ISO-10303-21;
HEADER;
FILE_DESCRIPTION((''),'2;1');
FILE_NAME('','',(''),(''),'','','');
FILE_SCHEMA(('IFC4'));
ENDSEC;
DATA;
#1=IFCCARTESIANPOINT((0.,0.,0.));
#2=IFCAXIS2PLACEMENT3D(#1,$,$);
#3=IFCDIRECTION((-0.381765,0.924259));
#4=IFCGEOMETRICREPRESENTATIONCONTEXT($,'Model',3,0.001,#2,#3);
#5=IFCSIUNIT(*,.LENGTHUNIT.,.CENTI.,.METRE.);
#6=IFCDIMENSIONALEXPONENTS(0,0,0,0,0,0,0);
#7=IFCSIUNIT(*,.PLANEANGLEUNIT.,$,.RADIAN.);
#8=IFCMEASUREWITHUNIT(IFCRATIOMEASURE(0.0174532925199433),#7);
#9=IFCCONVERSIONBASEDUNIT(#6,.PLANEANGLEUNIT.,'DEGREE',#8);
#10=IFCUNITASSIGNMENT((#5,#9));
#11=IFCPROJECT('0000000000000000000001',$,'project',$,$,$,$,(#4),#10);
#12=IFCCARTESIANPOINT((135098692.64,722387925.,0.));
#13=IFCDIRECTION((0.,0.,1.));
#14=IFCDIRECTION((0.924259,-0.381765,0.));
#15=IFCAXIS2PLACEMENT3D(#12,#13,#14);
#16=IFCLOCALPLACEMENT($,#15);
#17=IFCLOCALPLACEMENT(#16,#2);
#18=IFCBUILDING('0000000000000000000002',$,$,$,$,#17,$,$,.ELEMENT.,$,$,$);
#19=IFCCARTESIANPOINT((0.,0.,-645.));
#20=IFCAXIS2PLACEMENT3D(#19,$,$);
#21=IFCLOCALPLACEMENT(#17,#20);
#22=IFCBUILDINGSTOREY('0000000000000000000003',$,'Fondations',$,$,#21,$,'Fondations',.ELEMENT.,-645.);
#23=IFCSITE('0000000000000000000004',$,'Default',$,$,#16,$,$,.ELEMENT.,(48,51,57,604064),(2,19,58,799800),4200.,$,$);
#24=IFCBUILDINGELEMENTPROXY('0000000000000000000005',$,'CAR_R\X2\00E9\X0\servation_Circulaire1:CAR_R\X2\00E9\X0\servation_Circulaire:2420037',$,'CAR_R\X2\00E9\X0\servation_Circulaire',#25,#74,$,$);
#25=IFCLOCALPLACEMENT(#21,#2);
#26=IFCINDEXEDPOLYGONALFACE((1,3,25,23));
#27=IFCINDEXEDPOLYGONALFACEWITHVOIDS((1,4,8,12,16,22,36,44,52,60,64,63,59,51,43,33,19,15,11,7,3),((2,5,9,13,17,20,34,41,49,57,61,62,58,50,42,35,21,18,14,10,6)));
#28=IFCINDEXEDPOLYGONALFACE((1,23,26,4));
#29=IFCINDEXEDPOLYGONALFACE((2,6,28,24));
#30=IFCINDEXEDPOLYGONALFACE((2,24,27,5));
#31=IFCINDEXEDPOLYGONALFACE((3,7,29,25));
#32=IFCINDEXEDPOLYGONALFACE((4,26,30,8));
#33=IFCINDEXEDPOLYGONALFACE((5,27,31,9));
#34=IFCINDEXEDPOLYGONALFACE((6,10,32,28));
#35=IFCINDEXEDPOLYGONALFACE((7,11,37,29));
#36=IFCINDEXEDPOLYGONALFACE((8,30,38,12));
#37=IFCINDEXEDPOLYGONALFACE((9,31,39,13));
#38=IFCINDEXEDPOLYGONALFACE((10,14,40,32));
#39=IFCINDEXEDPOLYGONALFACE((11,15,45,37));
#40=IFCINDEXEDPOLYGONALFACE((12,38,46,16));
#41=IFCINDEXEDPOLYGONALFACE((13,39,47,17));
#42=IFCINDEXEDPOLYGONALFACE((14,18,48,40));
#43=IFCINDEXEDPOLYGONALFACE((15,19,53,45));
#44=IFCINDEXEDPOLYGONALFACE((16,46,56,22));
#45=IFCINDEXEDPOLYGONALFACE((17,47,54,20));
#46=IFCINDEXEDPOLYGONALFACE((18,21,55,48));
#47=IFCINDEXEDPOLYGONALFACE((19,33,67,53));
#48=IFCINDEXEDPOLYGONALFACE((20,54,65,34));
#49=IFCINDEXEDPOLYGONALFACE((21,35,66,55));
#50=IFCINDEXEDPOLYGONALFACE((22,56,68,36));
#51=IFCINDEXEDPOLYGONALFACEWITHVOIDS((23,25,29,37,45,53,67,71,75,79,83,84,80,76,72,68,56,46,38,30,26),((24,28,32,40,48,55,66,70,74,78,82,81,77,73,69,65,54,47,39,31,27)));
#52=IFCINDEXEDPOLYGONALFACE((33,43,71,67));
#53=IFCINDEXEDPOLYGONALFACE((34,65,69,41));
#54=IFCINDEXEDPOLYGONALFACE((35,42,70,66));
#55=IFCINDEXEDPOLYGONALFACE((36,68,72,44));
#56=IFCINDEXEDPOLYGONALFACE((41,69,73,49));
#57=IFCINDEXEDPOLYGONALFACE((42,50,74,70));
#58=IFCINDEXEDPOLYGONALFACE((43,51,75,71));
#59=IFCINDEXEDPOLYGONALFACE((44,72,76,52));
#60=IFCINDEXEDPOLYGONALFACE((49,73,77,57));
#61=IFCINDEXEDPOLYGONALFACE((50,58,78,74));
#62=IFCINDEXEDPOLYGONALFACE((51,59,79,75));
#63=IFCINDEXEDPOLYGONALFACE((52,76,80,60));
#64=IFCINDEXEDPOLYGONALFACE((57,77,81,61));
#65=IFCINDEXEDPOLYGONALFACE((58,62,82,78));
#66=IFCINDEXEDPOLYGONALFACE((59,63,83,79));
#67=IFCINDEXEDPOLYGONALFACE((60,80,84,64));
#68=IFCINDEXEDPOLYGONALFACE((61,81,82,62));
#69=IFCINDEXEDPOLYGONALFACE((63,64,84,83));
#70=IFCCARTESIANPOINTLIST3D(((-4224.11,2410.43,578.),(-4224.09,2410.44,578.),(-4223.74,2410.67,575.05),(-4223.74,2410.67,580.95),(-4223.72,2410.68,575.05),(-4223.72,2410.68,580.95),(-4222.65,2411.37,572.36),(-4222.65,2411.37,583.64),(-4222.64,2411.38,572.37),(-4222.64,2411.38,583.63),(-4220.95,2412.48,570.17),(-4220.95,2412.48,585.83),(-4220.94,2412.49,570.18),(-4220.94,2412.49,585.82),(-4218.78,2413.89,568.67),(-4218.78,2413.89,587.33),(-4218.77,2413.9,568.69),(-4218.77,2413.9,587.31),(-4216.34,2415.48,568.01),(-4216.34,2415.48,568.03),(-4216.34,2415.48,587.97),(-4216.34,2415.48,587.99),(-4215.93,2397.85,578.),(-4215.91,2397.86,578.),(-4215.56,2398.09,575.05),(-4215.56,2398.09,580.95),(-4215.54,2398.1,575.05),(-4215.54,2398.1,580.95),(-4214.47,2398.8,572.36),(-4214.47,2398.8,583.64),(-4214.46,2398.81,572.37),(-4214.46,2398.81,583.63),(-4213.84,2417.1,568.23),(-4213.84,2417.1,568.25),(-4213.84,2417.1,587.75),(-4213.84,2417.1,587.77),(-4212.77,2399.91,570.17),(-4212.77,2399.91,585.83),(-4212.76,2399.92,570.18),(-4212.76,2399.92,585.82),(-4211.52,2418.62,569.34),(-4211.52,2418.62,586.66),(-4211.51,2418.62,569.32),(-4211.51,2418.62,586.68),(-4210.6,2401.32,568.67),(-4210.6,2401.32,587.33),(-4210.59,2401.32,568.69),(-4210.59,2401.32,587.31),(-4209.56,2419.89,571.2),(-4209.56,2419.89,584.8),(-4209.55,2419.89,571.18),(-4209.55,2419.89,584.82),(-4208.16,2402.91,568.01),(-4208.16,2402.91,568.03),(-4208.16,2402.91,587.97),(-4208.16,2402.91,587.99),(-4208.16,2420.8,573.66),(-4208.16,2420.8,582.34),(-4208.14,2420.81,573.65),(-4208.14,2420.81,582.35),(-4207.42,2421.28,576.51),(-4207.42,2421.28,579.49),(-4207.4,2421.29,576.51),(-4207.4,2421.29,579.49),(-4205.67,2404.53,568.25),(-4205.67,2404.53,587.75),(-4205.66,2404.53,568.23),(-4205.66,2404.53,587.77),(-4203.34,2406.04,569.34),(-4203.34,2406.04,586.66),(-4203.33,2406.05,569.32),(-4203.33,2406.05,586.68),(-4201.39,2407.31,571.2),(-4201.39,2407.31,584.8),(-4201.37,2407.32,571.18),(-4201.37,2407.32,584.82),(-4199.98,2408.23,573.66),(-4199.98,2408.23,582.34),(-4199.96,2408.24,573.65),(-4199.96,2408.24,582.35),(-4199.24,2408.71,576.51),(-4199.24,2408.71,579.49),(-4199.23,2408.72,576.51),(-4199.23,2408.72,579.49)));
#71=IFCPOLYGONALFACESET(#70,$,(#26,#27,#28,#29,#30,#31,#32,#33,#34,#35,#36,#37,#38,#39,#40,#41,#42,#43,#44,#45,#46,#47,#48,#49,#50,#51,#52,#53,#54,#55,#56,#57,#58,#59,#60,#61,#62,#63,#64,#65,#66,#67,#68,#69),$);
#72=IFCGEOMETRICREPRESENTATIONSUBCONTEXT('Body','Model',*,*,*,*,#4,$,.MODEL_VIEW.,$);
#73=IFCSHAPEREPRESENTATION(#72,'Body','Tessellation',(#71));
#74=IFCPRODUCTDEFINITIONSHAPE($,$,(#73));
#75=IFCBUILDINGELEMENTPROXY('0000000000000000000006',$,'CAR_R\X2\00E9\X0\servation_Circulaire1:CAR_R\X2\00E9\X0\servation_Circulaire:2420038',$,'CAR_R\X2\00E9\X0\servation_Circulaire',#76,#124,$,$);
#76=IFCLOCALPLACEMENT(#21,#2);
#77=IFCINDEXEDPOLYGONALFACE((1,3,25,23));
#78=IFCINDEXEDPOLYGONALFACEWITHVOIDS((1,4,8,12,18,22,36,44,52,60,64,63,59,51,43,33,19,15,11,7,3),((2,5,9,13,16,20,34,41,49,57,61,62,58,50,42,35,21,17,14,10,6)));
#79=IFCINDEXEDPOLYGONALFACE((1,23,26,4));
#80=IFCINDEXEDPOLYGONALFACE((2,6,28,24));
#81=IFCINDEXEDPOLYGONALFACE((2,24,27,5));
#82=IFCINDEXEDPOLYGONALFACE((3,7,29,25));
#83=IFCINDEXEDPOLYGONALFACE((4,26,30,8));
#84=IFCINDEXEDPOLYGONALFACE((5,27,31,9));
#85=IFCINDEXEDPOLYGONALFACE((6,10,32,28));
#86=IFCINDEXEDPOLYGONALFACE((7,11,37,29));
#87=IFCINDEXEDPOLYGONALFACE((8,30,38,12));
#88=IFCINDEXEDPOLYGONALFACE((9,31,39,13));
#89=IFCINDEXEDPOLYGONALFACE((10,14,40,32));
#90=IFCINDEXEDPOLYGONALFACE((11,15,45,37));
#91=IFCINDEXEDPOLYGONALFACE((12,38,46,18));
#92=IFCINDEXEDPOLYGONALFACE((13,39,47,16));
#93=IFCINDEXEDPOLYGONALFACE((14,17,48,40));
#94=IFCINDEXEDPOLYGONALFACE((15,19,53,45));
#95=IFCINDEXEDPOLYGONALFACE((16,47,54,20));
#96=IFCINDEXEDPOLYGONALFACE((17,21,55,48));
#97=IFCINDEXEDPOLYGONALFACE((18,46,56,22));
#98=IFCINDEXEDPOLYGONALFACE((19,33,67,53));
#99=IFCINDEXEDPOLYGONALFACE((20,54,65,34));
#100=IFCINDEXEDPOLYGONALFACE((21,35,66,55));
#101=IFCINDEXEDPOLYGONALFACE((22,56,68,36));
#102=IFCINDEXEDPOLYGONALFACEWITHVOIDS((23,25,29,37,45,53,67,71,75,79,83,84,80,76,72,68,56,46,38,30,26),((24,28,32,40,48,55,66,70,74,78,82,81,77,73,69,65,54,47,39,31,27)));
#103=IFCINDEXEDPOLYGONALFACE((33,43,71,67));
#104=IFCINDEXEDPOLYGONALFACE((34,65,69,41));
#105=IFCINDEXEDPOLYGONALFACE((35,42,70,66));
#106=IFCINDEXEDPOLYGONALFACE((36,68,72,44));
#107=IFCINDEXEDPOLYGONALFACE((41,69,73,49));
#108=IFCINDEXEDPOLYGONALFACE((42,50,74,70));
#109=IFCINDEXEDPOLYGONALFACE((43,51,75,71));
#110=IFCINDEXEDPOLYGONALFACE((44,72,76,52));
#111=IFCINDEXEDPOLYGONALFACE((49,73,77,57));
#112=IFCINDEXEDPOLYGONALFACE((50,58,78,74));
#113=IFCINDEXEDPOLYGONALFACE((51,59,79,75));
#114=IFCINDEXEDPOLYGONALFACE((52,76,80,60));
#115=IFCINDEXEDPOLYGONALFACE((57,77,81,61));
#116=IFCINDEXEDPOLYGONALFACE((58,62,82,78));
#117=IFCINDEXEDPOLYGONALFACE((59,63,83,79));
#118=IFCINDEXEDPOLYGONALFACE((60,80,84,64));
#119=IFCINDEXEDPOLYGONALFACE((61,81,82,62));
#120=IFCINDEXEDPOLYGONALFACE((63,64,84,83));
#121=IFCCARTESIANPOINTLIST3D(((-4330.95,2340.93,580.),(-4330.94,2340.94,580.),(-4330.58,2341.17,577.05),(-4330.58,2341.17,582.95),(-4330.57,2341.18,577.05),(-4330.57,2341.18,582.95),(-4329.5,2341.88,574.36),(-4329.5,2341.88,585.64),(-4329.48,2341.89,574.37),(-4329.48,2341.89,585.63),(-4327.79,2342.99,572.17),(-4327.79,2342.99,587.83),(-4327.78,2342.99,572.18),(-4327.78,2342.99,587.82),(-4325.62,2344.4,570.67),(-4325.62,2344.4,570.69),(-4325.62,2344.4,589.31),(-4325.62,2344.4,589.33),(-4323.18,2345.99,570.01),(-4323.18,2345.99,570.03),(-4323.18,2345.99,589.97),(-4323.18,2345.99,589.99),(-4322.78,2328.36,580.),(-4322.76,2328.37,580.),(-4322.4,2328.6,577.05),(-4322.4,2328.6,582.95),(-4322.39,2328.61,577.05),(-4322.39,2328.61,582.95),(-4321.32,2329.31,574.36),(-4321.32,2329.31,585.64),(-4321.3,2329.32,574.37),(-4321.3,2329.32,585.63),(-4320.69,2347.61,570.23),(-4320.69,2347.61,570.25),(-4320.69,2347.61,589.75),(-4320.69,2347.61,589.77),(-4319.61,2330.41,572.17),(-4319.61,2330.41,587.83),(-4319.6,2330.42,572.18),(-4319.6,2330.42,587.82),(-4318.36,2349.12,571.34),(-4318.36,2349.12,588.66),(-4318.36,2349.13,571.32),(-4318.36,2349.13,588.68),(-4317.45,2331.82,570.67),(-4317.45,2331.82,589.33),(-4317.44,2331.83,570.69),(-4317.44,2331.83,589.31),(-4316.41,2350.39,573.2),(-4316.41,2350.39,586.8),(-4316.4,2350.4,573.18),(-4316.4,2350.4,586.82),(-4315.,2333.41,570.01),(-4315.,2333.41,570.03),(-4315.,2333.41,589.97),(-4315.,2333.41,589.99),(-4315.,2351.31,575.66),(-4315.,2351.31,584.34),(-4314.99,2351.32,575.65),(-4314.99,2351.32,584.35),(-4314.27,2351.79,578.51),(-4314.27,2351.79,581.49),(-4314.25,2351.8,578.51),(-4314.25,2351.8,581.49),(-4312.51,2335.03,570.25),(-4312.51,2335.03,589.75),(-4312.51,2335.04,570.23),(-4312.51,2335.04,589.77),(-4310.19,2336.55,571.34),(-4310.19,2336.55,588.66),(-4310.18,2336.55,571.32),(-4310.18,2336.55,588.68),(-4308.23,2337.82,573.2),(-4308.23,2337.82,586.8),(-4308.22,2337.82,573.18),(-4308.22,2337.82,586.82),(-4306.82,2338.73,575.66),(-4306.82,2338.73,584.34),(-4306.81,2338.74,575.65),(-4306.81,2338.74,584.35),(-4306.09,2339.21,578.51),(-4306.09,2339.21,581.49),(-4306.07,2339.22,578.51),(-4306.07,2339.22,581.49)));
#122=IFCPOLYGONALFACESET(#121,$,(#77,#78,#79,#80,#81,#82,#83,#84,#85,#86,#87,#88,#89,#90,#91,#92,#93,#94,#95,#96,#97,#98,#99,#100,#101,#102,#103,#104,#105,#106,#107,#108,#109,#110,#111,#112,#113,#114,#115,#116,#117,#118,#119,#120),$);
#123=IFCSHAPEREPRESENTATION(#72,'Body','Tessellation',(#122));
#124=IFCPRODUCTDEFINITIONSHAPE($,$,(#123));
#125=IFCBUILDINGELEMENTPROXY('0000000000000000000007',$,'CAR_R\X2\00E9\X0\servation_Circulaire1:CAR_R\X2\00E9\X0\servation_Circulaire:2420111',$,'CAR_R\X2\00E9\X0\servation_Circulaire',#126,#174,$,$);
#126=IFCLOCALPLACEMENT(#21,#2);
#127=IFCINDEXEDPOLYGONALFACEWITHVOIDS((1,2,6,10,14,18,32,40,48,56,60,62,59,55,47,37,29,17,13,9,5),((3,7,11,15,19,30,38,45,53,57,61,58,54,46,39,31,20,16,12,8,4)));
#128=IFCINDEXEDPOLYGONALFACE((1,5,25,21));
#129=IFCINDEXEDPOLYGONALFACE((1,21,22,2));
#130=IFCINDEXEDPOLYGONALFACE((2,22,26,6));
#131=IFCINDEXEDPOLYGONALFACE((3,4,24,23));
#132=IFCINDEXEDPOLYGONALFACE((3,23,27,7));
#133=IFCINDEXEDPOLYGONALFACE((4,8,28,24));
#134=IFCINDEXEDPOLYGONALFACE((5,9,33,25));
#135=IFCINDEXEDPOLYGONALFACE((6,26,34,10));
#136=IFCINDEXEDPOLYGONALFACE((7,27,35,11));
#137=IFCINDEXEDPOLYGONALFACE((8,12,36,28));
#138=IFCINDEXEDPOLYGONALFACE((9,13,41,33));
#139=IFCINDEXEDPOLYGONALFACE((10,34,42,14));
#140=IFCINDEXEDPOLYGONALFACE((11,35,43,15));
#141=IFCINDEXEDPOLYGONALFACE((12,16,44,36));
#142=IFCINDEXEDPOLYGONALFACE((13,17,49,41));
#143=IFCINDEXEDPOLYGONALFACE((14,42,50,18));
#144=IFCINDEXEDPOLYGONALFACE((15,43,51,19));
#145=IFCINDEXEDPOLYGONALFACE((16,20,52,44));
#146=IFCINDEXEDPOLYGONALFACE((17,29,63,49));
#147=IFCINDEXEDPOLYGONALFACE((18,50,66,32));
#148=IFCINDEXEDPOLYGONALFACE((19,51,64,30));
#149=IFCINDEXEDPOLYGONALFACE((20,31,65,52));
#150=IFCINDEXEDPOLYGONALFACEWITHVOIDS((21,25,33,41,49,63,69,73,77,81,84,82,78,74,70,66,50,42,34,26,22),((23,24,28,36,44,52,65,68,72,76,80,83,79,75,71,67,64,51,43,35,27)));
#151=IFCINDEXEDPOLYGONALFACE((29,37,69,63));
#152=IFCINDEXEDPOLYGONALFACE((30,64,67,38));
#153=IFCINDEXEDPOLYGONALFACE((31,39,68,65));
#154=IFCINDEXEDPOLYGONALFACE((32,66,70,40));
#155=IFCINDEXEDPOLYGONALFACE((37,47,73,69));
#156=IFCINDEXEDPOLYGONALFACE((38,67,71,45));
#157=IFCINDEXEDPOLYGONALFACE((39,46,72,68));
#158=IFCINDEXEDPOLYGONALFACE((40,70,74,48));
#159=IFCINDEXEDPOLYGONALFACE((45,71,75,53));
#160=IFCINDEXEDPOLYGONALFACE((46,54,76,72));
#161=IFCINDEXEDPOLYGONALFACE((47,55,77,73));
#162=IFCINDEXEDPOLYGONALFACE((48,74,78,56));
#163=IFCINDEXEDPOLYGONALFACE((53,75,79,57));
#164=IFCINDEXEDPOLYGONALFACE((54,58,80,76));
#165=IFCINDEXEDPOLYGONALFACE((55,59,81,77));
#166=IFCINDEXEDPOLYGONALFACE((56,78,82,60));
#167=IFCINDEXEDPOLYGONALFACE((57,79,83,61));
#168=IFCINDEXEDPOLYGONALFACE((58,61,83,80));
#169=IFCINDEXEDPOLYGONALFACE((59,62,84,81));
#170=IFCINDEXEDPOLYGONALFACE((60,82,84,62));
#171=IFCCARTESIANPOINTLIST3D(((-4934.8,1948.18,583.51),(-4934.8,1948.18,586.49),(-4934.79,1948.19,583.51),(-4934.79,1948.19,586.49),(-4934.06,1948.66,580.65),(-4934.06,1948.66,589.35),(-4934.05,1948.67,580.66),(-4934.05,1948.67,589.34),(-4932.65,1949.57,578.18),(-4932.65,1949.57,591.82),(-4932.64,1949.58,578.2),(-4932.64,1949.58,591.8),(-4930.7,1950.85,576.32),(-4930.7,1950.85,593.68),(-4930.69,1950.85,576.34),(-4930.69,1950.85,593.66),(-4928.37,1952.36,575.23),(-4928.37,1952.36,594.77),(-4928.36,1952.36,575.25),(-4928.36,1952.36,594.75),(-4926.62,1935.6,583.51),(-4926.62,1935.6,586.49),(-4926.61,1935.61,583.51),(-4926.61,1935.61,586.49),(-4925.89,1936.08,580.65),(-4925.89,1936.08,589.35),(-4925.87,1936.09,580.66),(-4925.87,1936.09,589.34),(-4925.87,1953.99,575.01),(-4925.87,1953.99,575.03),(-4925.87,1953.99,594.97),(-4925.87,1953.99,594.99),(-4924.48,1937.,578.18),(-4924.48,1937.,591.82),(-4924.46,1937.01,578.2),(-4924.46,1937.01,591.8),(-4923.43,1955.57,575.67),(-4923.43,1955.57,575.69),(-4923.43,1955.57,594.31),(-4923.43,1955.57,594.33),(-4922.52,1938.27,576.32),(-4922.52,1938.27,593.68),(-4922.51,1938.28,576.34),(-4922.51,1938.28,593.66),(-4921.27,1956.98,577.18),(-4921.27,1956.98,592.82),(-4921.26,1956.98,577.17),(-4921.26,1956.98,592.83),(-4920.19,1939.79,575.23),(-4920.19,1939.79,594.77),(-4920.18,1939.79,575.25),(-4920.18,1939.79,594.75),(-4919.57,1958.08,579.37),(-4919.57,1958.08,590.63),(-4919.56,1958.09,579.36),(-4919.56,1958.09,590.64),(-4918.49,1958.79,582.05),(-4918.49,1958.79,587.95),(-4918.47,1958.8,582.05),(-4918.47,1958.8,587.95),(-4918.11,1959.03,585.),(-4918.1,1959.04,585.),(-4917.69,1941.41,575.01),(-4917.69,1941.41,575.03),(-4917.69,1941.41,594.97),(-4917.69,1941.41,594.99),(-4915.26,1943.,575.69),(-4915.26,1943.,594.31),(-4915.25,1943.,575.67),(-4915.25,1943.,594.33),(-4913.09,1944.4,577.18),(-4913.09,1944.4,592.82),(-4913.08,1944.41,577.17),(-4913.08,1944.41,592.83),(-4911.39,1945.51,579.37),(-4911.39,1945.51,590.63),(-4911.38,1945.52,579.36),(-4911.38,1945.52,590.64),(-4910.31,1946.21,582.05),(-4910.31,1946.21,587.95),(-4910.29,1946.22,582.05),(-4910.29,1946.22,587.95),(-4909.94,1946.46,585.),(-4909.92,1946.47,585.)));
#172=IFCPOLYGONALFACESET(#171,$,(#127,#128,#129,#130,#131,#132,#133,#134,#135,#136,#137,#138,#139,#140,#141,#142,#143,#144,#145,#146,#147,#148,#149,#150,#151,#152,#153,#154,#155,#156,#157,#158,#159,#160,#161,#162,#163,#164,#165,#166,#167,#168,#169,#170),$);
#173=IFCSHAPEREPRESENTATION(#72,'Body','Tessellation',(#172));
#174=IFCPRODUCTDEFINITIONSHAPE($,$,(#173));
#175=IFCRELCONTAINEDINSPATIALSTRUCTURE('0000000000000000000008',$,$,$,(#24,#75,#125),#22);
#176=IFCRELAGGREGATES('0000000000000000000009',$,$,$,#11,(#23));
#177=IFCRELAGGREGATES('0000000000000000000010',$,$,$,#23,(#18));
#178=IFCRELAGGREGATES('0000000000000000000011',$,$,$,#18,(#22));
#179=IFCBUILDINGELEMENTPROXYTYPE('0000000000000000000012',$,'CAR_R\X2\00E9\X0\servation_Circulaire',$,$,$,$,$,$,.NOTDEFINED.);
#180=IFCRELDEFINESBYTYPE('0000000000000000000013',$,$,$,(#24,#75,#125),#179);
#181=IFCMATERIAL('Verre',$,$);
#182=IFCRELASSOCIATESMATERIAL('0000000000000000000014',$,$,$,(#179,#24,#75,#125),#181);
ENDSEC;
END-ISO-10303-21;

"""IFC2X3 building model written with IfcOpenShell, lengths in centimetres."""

from ifc_helpers import new_model, entity, si_unit, converted_unit, direction, frame, frame_2d, origin, place, context, subcontext, project, spatial, hollow_circle, extrude, source, transform, mapped, material, type_object, type_shapes, element, save


model = new_model("IFC2X3")

# Units and contexts
model_context = context("Model", 3, precision=0.001, world=origin(), true_north=direction((-0.381765, 0.924259)))
body_context = subcontext(model_context, "Body", "Model", "MODEL_VIEW")
ifc_project = project(units=[si_unit("LENGTHUNIT", "METRE", prefix="CENTI"), converted_unit("PLANEANGLEUNIT", "DEGREE", entity("IfcRatioMeasure", 0.0174532925199433), si_unit("PLANEANGLEUNIT", "RADIAN"), dimensions=[0, 0, 0, 0, 0, 0, 0])], contexts=[model_context])

# Site, building, storey
site_placement = place(None, frame((135098692.64, 722387925.0, 0.0), z_axis=(0.0, 0.0, 1.0), x_axis=(0.924259, -0.381765, 0.0)))
site = spatial("IfcSite", under=ifc_project, at=site_placement, Name="Default", CompositionType="ELEMENT", RefLatitude=(48, 51, 57, 604064), RefLongitude=(2, 19, 58, 799800), RefElevation=4200.0)
building_placement = place(site_placement, origin())
building = spatial("IfcBuilding", under=site, at=building_placement, CompositionType="ELEMENT")
storey_placement = place(building_placement, frame((0.0, 0.0, -645.0)))
storey = spatial("IfcBuildingStorey", under=building, at=storey_placement, Name="Fondations", LongName="Fondations", CompositionType="ELEMENT", Elevation=-645.0)

# Building element proxies
ifc_material_1 = material(Name="Verre")
building_element_proxy_type_1 = type_object("IfcBuildingElementProxyType", Name="CAR_Réservation_Circulaire", PredefinedType="NOTDEFINED", material=ifc_material_1)
shared_shape_1 = source(origin(), body_context, "Body", "SweptSolid", [
    extrude(hollow_circle(Radius=10.02, WallThickness=0.02, at=frame_2d((0.0, 0.0), x_axis=(1.0, 0.0))), frame((0.0, 0.0, -15.0)), (0.0, 0.0, 1.0), 15.0),
])
type_shapes(building_element_proxy_type_1, [shared_shape_1])
for number, where, z_axis, x_axis, name in (
    (1, (-4215.71, 2415.89, 578.0), (-0.545236, 0.838282, 0.0), (-0.838282, -0.545236, 0.0), "CAR_Réservation_Circulaire1:CAR_Réservation_Circulaire:2420037"),
    (2, (-4322.56, 2346.39, 580.0), (-0.545236, 0.838282, 0.0), (-0.838282, -0.545236, 0.0), "CAR_Réservation_Circulaire1:CAR_Réservation_Circulaire:2420038"),
    (3, (-4918.32, 1941.0, 585.0), (0.545236, -0.838282, 0.0), (0.838282, 0.545236, 0.0), "CAR_Réservation_Circulaire1:CAR_Réservation_Circulaire:2420111"),
):
    element("IfcBuildingElementProxy", number, at=place(storey_placement, frame(where, z_axis=z_axis, x_axis=x_axis)), inside=storey, type_object=building_element_proxy_type_1, material=ifc_material_1, Name=name, ObjectType="CAR_Réservation_Circulaire", context=body_context, shape_type="MappedRepresentation", body=[
        mapped(shared_shape_1, transform((0.0, 0.0, 0.0), scale=1.0)),
    ])

save(model, "model.ifc")
